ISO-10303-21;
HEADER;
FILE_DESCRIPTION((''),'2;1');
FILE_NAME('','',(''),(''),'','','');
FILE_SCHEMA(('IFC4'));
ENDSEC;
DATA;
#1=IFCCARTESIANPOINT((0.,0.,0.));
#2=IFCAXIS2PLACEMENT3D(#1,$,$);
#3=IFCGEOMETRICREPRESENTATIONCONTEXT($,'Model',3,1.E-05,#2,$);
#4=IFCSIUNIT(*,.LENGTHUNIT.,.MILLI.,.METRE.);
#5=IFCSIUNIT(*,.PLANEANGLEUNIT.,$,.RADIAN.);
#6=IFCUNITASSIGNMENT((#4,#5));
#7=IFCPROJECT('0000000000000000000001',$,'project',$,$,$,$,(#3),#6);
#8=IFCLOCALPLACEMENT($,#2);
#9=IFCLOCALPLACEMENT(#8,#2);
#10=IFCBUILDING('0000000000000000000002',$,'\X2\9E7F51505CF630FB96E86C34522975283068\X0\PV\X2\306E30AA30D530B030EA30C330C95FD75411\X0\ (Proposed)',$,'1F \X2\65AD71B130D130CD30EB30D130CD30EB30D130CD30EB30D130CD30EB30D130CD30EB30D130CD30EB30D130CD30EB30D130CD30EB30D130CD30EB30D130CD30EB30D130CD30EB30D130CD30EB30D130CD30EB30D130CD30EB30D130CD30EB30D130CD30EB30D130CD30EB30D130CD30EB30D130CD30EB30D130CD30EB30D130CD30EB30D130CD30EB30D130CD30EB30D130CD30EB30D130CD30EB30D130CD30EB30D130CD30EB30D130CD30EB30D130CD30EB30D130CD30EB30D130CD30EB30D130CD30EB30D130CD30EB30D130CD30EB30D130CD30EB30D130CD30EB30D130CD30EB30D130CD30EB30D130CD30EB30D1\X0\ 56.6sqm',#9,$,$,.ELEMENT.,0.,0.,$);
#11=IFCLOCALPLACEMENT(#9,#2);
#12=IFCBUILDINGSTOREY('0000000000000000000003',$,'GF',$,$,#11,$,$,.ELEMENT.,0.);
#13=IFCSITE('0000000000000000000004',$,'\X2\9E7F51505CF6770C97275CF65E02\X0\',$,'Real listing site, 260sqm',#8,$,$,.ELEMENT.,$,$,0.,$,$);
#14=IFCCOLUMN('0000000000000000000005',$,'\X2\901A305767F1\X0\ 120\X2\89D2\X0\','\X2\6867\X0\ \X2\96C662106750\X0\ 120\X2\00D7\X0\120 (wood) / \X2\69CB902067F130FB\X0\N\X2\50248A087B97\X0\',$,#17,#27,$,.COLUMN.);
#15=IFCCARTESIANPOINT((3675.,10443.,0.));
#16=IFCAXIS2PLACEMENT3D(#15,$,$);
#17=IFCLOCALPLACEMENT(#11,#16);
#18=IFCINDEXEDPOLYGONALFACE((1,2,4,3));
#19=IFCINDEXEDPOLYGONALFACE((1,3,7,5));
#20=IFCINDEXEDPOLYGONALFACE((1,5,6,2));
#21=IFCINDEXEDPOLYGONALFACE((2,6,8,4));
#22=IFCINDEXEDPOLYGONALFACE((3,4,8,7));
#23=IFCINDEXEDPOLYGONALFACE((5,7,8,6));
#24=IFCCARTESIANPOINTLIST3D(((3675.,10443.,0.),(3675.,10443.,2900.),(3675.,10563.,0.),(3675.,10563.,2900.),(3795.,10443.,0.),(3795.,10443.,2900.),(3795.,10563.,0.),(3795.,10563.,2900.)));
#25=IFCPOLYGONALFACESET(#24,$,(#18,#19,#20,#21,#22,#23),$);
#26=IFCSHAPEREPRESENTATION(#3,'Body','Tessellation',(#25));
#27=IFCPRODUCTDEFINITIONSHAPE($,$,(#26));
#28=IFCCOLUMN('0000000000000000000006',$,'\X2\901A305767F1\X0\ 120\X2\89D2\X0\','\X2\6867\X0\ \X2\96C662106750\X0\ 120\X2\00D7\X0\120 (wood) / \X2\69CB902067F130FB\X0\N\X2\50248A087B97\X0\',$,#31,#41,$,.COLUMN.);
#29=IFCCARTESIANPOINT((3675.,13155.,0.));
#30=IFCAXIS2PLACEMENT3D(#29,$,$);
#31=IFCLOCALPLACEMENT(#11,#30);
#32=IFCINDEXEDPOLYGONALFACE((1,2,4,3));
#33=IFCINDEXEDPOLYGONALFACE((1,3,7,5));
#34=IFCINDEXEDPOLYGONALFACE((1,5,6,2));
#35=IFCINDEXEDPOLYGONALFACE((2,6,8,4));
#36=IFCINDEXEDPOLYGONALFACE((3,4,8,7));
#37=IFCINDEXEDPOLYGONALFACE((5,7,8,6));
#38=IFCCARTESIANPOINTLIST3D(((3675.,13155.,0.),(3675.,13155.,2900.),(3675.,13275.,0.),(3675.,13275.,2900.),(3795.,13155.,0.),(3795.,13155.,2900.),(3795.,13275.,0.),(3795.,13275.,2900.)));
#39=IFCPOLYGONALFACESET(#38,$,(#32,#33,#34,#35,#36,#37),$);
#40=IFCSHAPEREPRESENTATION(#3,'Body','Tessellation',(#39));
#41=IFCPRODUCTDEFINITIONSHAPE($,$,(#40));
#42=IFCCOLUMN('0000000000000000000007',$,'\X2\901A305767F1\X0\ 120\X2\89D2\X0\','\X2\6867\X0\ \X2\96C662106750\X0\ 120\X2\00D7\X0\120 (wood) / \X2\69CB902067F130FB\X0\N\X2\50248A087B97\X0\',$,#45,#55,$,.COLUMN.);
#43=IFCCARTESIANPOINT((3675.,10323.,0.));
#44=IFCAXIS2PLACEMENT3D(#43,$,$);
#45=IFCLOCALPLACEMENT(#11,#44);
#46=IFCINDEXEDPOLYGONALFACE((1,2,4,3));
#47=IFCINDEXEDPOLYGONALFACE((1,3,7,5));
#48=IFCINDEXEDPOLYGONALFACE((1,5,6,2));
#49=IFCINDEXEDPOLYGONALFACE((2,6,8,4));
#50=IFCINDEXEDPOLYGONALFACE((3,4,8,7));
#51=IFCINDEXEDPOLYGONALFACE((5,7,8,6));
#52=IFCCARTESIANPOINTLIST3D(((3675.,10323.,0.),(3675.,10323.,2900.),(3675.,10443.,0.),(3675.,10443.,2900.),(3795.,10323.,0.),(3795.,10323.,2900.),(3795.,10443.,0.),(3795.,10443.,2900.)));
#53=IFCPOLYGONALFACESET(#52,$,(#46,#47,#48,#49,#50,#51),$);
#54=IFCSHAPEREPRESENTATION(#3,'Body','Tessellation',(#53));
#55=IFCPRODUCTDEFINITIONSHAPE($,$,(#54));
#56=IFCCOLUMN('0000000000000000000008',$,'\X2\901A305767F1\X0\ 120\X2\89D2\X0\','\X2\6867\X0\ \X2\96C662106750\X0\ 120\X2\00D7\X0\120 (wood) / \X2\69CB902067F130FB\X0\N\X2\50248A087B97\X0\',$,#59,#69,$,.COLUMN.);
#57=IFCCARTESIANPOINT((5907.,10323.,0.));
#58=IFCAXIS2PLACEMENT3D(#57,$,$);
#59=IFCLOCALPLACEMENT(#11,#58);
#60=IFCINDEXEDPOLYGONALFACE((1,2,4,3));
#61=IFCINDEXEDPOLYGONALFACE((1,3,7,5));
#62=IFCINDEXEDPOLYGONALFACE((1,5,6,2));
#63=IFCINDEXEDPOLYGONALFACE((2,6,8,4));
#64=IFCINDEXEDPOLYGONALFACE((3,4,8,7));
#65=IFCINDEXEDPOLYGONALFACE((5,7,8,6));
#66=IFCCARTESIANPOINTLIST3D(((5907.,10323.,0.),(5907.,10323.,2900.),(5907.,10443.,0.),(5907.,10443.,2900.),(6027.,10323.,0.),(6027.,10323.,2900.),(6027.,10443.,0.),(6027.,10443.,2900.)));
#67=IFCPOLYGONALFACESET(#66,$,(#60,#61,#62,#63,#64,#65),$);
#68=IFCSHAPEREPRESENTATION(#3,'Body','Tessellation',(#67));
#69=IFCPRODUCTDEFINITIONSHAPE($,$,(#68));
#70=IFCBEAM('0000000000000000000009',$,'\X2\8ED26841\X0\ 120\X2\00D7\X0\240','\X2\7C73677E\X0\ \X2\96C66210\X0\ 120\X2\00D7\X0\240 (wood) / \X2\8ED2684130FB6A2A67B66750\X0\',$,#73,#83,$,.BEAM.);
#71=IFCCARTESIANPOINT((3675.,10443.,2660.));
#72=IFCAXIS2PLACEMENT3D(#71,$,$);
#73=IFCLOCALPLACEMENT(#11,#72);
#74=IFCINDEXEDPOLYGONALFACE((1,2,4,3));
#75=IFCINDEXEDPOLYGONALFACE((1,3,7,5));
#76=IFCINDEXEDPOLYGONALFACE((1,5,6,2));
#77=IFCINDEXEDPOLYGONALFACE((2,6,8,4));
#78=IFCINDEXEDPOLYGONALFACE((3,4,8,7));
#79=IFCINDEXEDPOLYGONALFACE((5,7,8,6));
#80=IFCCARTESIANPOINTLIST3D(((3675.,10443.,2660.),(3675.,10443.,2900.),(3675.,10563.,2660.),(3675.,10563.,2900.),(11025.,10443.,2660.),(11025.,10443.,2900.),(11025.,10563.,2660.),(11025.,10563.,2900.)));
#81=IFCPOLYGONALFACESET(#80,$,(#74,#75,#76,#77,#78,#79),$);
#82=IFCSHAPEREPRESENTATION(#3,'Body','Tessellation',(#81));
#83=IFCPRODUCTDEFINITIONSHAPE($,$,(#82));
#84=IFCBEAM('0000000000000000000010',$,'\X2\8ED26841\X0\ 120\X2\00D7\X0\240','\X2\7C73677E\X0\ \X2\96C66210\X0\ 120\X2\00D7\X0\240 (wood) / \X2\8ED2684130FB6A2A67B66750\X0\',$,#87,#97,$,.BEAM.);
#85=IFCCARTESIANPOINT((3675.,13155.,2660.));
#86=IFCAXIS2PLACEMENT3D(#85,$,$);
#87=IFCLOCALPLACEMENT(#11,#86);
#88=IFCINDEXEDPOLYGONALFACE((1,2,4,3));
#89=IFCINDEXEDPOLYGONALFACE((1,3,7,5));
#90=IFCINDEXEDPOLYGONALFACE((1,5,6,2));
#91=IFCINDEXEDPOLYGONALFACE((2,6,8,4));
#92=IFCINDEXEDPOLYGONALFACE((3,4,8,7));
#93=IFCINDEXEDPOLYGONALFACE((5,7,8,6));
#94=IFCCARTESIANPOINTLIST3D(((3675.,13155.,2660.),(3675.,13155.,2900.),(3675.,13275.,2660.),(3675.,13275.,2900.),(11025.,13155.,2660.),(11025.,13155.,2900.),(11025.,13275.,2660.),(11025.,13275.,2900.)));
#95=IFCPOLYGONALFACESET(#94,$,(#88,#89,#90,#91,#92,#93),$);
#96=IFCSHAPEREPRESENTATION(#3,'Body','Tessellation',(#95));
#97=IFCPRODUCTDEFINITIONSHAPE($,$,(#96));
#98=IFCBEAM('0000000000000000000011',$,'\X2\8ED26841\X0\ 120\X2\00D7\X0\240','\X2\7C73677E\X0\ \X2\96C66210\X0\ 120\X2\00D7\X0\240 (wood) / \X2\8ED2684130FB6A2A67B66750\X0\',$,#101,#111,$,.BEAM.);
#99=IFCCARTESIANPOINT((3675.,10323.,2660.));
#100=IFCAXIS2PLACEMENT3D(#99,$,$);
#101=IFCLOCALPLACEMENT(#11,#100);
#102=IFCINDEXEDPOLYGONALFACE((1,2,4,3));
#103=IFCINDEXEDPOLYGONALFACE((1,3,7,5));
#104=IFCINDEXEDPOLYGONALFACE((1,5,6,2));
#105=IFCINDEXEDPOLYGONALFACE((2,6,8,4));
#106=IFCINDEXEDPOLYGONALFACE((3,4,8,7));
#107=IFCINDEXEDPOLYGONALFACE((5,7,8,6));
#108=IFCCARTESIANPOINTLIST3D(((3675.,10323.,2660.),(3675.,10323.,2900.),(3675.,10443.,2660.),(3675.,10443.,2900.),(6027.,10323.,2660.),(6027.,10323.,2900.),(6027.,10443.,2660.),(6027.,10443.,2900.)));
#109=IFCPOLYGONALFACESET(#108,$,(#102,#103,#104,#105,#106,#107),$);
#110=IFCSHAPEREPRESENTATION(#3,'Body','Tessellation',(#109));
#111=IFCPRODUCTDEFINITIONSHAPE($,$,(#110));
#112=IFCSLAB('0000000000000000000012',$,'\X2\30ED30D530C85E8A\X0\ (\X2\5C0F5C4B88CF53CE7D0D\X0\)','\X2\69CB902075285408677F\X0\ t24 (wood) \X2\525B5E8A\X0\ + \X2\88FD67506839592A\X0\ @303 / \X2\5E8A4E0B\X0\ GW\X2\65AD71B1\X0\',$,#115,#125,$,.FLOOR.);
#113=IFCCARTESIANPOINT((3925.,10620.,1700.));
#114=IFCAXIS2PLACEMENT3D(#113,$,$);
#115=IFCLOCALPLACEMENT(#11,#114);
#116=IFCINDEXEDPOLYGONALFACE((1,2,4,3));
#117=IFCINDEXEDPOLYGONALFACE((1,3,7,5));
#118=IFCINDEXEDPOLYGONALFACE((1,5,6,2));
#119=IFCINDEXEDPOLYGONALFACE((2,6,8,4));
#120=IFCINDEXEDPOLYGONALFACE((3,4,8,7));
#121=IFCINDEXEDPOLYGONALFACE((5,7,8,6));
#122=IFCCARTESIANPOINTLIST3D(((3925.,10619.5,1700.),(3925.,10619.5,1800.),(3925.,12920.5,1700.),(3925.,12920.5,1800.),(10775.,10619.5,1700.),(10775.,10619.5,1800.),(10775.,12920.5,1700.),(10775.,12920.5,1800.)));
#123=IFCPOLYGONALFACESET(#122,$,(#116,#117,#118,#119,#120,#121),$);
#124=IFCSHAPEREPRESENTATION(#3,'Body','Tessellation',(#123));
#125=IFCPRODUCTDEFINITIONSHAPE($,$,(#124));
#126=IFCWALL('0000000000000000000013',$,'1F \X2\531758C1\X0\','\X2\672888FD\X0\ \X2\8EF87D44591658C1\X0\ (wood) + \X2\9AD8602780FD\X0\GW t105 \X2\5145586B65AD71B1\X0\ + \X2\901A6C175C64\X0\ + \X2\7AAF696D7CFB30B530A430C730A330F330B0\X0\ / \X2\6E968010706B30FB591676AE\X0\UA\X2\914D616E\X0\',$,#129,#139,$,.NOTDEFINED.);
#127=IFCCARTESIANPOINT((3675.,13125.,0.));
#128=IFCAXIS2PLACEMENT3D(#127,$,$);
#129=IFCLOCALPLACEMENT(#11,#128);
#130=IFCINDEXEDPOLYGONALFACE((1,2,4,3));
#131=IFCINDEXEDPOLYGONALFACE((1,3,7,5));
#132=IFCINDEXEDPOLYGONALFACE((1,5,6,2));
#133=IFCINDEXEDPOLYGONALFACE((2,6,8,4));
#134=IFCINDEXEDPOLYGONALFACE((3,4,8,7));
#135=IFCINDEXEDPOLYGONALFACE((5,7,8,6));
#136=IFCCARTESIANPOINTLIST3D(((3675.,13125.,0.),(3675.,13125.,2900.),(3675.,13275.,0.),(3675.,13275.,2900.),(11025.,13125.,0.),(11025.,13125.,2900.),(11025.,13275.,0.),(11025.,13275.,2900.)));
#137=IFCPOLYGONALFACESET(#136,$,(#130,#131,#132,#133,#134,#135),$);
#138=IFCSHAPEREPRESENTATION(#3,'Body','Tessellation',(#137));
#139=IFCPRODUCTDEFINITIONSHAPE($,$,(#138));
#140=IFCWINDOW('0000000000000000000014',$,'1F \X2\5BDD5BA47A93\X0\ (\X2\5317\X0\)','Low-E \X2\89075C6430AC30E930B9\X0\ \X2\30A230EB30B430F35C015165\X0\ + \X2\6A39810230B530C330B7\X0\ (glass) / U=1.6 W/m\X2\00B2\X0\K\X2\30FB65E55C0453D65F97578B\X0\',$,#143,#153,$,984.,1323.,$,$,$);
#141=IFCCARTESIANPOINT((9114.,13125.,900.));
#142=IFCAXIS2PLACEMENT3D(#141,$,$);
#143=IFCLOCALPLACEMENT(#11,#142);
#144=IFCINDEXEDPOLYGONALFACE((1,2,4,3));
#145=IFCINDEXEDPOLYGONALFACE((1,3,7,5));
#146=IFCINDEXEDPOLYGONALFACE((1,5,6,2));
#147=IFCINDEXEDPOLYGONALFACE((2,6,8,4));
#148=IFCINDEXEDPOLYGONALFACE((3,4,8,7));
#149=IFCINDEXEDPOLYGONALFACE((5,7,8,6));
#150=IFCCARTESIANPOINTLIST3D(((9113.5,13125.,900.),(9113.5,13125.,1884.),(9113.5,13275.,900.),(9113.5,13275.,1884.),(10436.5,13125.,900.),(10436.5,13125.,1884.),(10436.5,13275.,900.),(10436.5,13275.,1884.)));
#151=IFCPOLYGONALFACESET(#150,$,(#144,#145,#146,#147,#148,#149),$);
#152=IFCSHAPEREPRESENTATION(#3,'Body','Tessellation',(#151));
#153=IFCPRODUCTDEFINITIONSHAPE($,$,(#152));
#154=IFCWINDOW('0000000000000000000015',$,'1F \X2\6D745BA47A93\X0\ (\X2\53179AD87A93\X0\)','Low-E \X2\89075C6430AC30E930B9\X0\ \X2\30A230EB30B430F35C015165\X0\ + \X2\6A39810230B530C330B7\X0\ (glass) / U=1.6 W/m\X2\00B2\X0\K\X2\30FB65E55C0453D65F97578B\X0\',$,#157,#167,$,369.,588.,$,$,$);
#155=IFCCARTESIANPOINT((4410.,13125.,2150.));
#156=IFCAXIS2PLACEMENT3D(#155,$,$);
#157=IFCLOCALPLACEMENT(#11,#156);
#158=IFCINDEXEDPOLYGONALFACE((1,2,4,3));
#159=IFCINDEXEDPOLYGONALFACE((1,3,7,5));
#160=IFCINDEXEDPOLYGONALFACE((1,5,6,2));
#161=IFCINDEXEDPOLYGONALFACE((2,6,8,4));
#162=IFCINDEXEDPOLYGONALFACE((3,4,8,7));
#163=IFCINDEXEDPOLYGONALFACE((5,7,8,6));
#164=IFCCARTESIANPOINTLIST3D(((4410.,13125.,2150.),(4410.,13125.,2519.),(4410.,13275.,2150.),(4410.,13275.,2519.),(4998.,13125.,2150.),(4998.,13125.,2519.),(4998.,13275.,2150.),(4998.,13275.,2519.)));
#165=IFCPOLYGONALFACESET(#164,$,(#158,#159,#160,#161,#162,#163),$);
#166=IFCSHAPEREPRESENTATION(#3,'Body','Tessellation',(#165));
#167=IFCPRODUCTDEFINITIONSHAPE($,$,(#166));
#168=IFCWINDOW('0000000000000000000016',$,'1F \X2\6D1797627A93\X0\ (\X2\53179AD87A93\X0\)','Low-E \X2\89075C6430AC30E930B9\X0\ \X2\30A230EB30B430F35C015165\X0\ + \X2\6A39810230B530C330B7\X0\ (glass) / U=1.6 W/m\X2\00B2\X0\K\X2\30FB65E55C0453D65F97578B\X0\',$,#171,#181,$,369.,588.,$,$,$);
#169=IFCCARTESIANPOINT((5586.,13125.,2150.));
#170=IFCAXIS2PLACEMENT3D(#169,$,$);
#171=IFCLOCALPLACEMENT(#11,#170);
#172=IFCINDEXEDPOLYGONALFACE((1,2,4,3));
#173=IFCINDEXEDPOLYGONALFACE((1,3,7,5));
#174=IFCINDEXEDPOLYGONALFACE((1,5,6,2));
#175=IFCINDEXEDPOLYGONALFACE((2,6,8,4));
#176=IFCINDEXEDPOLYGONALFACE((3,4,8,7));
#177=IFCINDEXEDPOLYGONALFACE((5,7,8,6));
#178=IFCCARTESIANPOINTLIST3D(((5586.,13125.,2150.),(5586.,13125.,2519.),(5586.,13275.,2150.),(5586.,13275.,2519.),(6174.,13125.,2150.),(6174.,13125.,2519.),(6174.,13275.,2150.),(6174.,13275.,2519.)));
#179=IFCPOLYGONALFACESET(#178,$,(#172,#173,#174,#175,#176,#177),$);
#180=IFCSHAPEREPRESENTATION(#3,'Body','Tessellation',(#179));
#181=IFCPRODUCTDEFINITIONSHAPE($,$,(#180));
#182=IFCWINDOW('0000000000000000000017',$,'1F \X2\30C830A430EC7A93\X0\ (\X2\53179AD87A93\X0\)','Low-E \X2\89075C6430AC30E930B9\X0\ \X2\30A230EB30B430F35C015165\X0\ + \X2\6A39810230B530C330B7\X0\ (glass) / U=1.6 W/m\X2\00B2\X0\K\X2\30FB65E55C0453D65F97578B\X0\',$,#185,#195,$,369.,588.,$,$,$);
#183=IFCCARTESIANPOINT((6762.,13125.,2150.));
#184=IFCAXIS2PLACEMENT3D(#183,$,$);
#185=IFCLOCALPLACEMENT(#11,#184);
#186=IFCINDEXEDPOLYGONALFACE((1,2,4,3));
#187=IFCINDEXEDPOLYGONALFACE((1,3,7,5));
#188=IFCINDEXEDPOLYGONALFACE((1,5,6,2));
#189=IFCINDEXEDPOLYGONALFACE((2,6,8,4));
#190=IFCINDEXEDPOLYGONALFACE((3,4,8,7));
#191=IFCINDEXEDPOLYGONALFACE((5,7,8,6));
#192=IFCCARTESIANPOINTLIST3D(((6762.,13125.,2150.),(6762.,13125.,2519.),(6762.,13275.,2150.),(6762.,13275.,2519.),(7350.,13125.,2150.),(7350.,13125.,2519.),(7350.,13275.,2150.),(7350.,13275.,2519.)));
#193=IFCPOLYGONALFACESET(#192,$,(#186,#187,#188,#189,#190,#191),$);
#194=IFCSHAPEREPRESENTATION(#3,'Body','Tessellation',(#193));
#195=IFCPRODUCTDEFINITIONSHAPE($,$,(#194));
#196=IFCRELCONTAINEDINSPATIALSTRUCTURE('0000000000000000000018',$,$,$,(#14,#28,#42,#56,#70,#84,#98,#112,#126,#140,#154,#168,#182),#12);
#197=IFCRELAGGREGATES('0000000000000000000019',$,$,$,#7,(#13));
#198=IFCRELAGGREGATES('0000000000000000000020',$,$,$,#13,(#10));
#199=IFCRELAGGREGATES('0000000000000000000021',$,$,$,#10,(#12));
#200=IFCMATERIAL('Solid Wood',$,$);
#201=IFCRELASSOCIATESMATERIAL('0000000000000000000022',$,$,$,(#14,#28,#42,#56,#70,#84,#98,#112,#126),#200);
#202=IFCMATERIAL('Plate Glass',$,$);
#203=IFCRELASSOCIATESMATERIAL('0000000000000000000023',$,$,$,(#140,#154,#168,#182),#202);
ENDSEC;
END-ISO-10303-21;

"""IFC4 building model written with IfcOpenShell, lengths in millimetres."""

from ifc_helpers import new_model, si_unit, frame, frame_2d, origin, place, context, project, spatial, rectangle, extrude, material, element, fill, save


model = new_model("IFC4")

# Units and contexts
model_context = context("Model", 3, precision=1e-05, world=origin())
ifc_project = project(units=[si_unit("LENGTHUNIT", "METRE", prefix="MILLI"), si_unit("PLANEANGLEUNIT", "RADIAN")], contexts=[model_context])

# Site, building, storey
site_placement = place(None, origin())
site = spatial("IfcSite", under=ifc_project, at=site_placement, Name="鹿児島県霧島市", ObjectType="Real listing site, 260sqm", CompositionType="ELEMENT", RefElevation=0.0)
building_placement = place(site_placement, origin())
building = spatial("IfcBuilding", under=site, at=building_placement, Name="鹿児島・雨水利用とPVのオフグリッド志向 (Proposed)", ObjectType="1F 断熱パネルパネルパネルパネルパネルパネルパネルパネルパネルパネルパネルパネルパネルパネルパネルパネルパネルパネルパネルパネルパネルパネルパネルパネルパネルパネルパネルパネルパネルパネルパネルパネルパネルパネルパネルパネルパネルパネルパネルパ 56.6sqm", CompositionType="ELEMENT", ElevationOfRefHeight=0.0, ElevationOfTerrain=0.0)
storey_placement = place(building_placement, origin())
storey = spatial("IfcBuildingStorey", under=building, at=storey_placement, Name="GF", CompositionType="ELEMENT", Elevation=0.0)

# Columns
ifc_material_1 = material(Name="Solid Wood")
column_1_placement = place(storey_placement, frame((3675.0, 10443.0, 0.0)))
element("IfcColumn", 1, at=column_1_placement, inside=storey, material=ifc_material_1, Name="通し柱 120角", Description="桧 集成材 120×120 (wood) / 構造柱・N値計算", PredefinedType="COLUMN", context=model_context, shape_type="SweptSolid", body=[
    extrude(rectangle(XDim=120.0, YDim=120.0, at=frame_2d((60.0, 60.0))), frame((3675.0, 10443.0, 0.0)), (0.0, 0.0, 1.0), 2900.0),
])
column_2_placement = place(storey_placement, frame((3675.0, 13155.0, 0.0)))
element("IfcColumn", 2, at=column_2_placement, inside=storey, material=ifc_material_1, Name="通し柱 120角", Description="桧 集成材 120×120 (wood) / 構造柱・N値計算", PredefinedType="COLUMN", context=model_context, shape_type="SweptSolid", body=[
    extrude(rectangle(XDim=120.0, YDim=120.0, at=frame_2d((60.0, 60.0))), frame((3675.0, 13155.0, 0.0)), (0.0, 0.0, 1.0), 2900.0),
])
column_3_placement = place(storey_placement, frame((3675.0, 10323.0, 0.0)))
element("IfcColumn", 3, at=column_3_placement, inside=storey, material=ifc_material_1, Name="通し柱 120角", Description="桧 集成材 120×120 (wood) / 構造柱・N値計算", PredefinedType="COLUMN", context=model_context, shape_type="SweptSolid", body=[
    extrude(rectangle(XDim=120.0, YDim=120.0, at=frame_2d((60.0, 60.0))), frame((3675.0, 10323.0, 0.0)), (0.0, 0.0, 1.0), 2900.0),
])
column_4_placement = place(storey_placement, frame((5907.0, 10323.0, 0.0)))
element("IfcColumn", 4, at=column_4_placement, inside=storey, material=ifc_material_1, Name="通し柱 120角", Description="桧 集成材 120×120 (wood) / 構造柱・N値計算", PredefinedType="COLUMN", context=model_context, shape_type="SweptSolid", body=[
    extrude(rectangle(XDim=120.0, YDim=120.0, at=frame_2d((60.0, 60.0))), frame((5907.0, 10323.0, 0.0)), (0.0, 0.0, 1.0), 2900.0),
])

# Beams
beam_1_placement = place(storey_placement, frame((3675.0, 10443.0, 2660.0)))
element("IfcBeam", 5, at=beam_1_placement, inside=storey, material=ifc_material_1, Name="軒桁 120×240", Description="米松 集成 120×240 (wood) / 軒桁・横架材", PredefinedType="BEAM", context=model_context, shape_type="SweptSolid", body=[
    extrude(rectangle(XDim=7350.0, YDim=120.0, at=frame_2d((3675.0, 60.0))), frame((3675.0, 10443.0, 2660.0)), (0.0, 0.0, 1.0), 240.0),
])
beam_2_placement = place(storey_placement, frame((3675.0, 13155.0, 2660.0)))
element("IfcBeam", 6, at=beam_2_placement, inside=storey, material=ifc_material_1, Name="軒桁 120×240", Description="米松 集成 120×240 (wood) / 軒桁・横架材", PredefinedType="BEAM", context=model_context, shape_type="SweptSolid", body=[
    extrude(rectangle(XDim=7350.0, YDim=120.0, at=frame_2d((3675.0, 60.0))), frame((3675.0, 13155.0, 2660.0)), (0.0, 0.0, 1.0), 240.0),
])
beam_3_placement = place(storey_placement, frame((3675.0, 10323.0, 2660.0)))
element("IfcBeam", 7, at=beam_3_placement, inside=storey, material=ifc_material_1, Name="軒桁 120×240", Description="米松 集成 120×240 (wood) / 軒桁・横架材", PredefinedType="BEAM", context=model_context, shape_type="SweptSolid", body=[
    extrude(rectangle(XDim=2352.0, YDim=120.0, at=frame_2d((1176.0, 60.0))), frame((3675.0, 10323.0, 2660.0)), (0.0, 0.0, 1.0), 240.0),
])

# Slab
slab_1_placement = place(storey_placement, frame((3925.0, 10620.0, 1700.0)))
element("IfcSlab", 8, at=slab_1_placement, inside=storey, material=ifc_material_1, Name="ロフト床 (小屋裏収納)", Description="構造用合板 t24 (wood) 剛床 + 製材根太 @303 / 床下 GW断熱", PredefinedType="FLOOR", context=model_context, shape_type="SweptSolid", body=[
    extrude(rectangle(XDim=6850.0, YDim=2301.0, at=frame_2d((3425.0, 1150.0))), frame((3925.0, 10620.0, 1700.0)), (0.0, 0.0, 1.0), 100.0),
])

# Wall, openings, windows
wall_1_placement = place(storey_placement, frame((3675.0, 13125.0, 0.0)))
wall_1 = element("IfcWall", 9, at=wall_1_placement, inside=storey, material=ifc_material_1, Name="1F 北壁", Description="木製 軸組外壁 (wood) + 高性能GW t105 充填断熱 + 通気層 + 窯業系サイディング / 準耐火・外皮UA配慮", PredefinedType="NOTDEFINED", context=model_context, shape_type="SweptSolid", body=[
    extrude(rectangle(XDim=7350.0, YDim=150.0, at=frame_2d((3675.0, 75.0))), frame((3675.0, 13125.0, 0.0)), (0.0, 0.0, 1.0), 2900.0),
])
opening_1_placement = place(storey_placement, frame((9114.0, 13125.0, 900.0)))
opening_1 = element("IfcOpeningElement", 10, at=opening_1_placement, cuts=wall_1, PredefinedType="NOTDEFINED", context=model_context, shape_type="SweptSolid", body=[
    extrude(rectangle(XDim=1323.0, YDim=150.0, at=frame_2d((661.0, 75.0))), frame((9114.0, 13125.0, 900.0)), (0.0, 0.0, 1.0), 984.0),
])
opening_2_placement = place(storey_placement, frame((4410.0, 13125.0, 2150.0)))
opening_2 = element("IfcOpeningElement", 11, at=opening_2_placement, cuts=wall_1, PredefinedType="NOTDEFINED", context=model_context, shape_type="SweptSolid", body=[
    extrude(rectangle(XDim=588.0, YDim=150.0, at=frame_2d((294.0, 75.0))), frame((4410.0, 13125.0, 2150.0)), (0.0, 0.0, 1.0), 369.0),
])
opening_3_placement = place(storey_placement, frame((5586.0, 13125.0, 2150.0)))
opening_3 = element("IfcOpeningElement", 12, at=opening_3_placement, cuts=wall_1, PredefinedType="NOTDEFINED", context=model_context, shape_type="SweptSolid", body=[
    extrude(rectangle(XDim=588.0, YDim=150.0, at=frame_2d((294.0, 75.0))), frame((5586.0, 13125.0, 2150.0)), (0.0, 0.0, 1.0), 369.0),
])
opening_4_placement = place(storey_placement, frame((6762.0, 13125.0, 2150.0)))
opening_4 = element("IfcOpeningElement", 13, at=opening_4_placement, cuts=wall_1, PredefinedType="NOTDEFINED", context=model_context, shape_type="SweptSolid", body=[
    extrude(rectangle(XDim=588.0, YDim=150.0, at=frame_2d((294.0, 75.0))), frame((6762.0, 13125.0, 2150.0)), (0.0, 0.0, 1.0), 369.0),
])
ifc_material_2 = material(Name="Plate Glass")
window_1_placement = place(storey_placement, frame((9114.0, 13125.0, 900.0)))
window_1 = element("IfcWindow", 14, at=window_1_placement, inside=storey, material=ifc_material_2, Name="1F 寝室窓 (北)", Description="Low-E 複層ガラス アルゴン封入 + 樹脂サッシ (glass) / U=1.6 W/m²K・日射取得型", OverallHeight=984.0, OverallWidth=1323.0, context=model_context, shape_type="SweptSolid", body=[
    extrude(rectangle(XDim=1323.0, YDim=150.0, at=frame_2d((661.0, 75.0))), frame((9114.0, 13125.0, 900.0)), (0.0, 0.0, 1.0), 984.0),
])
fill(opening_1, window_1)
window_2_placement = place(storey_placement, frame((4410.0, 13125.0, 2150.0)))
window_2 = element("IfcWindow", 15, at=window_2_placement, inside=storey, material=ifc_material_2, Name="1F 浴室窓 (北高窓)", Description="Low-E 複層ガラス アルゴン封入 + 樹脂サッシ (glass) / U=1.6 W/m²K・日射取得型", OverallHeight=369.0, OverallWidth=588.0, context=model_context, shape_type="SweptSolid", body=[
    extrude(rectangle(XDim=588.0, YDim=150.0, at=frame_2d((294.0, 75.0))), frame((4410.0, 13125.0, 2150.0)), (0.0, 0.0, 1.0), 369.0),
])
fill(opening_2, window_2)
window_3_placement = place(storey_placement, frame((5586.0, 13125.0, 2150.0)))
window_3 = element("IfcWindow", 16, at=window_3_placement, inside=storey, material=ifc_material_2, Name="1F 洗面窓 (北高窓)", Description="Low-E 複層ガラス アルゴン封入 + 樹脂サッシ (glass) / U=1.6 W/m²K・日射取得型", OverallHeight=369.0, OverallWidth=588.0, context=model_context, shape_type="SweptSolid", body=[
    extrude(rectangle(XDim=588.0, YDim=150.0, at=frame_2d((294.0, 75.0))), frame((5586.0, 13125.0, 2150.0)), (0.0, 0.0, 1.0), 369.0),
])
fill(opening_3, window_3)
window_4_placement = place(storey_placement, frame((6762.0, 13125.0, 2150.0)))
window_4 = element("IfcWindow", 17, at=window_4_placement, inside=storey, material=ifc_material_2, Name="1F トイレ窓 (北高窓)", Description="Low-E 複層ガラス アルゴン封入 + 樹脂サッシ (glass) / U=1.6 W/m²K・日射取得型", OverallHeight=369.0, OverallWidth=588.0, context=model_context, shape_type="SweptSolid", body=[
    extrude(rectangle(XDim=588.0, YDim=150.0, at=frame_2d((294.0, 75.0))), frame((6762.0, 13125.0, 2150.0)), (0.0, 0.0, 1.0), 369.0),
])
fill(opening_4, window_4)

save(model, "model.ifc")
